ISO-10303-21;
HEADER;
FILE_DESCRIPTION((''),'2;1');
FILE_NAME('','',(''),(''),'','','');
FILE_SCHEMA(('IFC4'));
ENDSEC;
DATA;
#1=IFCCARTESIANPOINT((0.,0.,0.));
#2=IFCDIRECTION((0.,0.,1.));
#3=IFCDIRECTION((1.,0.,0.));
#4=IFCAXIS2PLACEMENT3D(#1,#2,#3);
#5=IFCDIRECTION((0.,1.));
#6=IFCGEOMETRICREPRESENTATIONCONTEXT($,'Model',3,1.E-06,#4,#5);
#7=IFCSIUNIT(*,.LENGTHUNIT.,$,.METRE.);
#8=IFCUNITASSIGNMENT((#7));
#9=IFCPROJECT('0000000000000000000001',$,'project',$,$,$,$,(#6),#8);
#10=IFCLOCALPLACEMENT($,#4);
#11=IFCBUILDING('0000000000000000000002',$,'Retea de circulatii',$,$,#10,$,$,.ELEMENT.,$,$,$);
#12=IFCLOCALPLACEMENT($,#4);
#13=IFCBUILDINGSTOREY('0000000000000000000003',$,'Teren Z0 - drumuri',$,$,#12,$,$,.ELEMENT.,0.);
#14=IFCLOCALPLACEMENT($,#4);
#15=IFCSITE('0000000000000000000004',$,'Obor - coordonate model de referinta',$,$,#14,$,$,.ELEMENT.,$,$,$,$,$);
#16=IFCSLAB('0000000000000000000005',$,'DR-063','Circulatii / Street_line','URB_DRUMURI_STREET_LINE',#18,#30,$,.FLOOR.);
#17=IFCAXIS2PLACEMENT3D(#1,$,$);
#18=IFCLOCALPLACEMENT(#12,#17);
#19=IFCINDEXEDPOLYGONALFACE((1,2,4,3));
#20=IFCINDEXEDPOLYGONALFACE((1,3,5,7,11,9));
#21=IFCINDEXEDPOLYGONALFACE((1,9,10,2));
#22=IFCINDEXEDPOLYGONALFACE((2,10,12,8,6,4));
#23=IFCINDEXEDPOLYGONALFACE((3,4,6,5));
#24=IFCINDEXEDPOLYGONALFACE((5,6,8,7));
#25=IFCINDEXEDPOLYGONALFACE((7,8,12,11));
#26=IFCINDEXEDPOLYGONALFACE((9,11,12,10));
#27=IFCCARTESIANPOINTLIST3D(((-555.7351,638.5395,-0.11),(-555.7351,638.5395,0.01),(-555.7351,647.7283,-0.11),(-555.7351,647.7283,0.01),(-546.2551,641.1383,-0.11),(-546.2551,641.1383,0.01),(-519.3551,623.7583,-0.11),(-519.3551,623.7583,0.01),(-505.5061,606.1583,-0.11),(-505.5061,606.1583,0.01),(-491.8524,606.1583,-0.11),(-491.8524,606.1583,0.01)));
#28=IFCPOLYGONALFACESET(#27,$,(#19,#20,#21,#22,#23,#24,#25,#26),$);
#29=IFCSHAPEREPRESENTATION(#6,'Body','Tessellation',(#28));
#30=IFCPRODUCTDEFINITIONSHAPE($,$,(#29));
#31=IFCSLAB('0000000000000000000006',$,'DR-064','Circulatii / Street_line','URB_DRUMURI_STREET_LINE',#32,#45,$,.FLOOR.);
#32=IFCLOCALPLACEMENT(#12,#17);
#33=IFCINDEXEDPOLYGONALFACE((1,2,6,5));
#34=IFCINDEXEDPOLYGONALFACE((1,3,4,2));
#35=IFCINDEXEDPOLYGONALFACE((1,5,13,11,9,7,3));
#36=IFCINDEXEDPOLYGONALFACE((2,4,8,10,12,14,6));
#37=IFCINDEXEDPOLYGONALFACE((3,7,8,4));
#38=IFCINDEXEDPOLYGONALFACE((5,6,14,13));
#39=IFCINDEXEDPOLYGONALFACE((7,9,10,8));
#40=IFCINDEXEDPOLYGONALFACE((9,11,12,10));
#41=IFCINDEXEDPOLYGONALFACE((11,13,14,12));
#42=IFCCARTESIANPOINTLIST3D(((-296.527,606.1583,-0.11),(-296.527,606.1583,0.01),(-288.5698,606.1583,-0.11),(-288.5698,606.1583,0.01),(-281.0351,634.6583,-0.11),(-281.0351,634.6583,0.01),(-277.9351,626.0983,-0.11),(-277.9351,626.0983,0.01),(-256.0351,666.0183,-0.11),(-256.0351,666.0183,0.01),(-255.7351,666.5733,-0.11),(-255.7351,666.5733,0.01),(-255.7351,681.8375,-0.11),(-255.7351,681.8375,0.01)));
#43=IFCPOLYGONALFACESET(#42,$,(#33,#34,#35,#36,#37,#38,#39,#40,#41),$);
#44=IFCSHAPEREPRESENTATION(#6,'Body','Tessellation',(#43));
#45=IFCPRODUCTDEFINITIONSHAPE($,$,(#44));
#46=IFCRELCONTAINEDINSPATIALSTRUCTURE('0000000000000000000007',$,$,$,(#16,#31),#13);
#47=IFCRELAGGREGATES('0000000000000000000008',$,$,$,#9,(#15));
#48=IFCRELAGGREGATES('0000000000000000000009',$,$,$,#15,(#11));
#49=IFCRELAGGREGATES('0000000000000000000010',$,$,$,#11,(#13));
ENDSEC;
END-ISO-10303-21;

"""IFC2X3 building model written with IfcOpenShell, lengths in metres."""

from ifc_helpers import new_model, si_unit, direction, frame, origin_with_axes, place, context, project, spatial, polyline, outline, extrude, element, save


model = new_model("IFC2X3")

# Units and contexts
model_context = context("Model", 3, precision=1e-06, world=origin_with_axes(), true_north=direction((0.0, 1.0)))
ifc_project = project(units=[si_unit("LENGTHUNIT", "METRE")], contexts=[model_context])

# Site, building, storey
site_placement = place(None, origin_with_axes())
site = spatial("IfcSite", under=ifc_project, at=site_placement, Name="Obor - coordonate model de referinta", CompositionType="ELEMENT")
building_placement = place(None, origin_with_axes())
building = spatial("IfcBuilding", under=site, at=building_placement, Name="Retea de circulatii", CompositionType="ELEMENT")
storey_placement = place(None, origin_with_axes())
storey = spatial("IfcBuildingStorey", under=building, at=storey_placement, Name="Teren Z0 - drumuri", CompositionType="ELEMENT", Elevation=0.0)

# Slabs
slab_1_placement = place(None, origin_with_axes())
element("IfcSlab", 1, at=slab_1_placement, inside=storey, Name="DR-063", Description="Circulatii / Street_line", ObjectType="URB_DRUMURI_STREET_LINE", PredefinedType="FLOOR", context=model_context, shape_type="SweptSolid", body=[
    extrude(outline(polyline([(-546.2551, 641.1383), (-555.7351, 647.7283), (-555.7351, 638.5395), (-505.5061, 606.1583), (-491.8524, 606.1583), (-519.3551, 623.7583), (-546.2551, 641.1383)])), frame((0.0, 0.0, -0.11), z_axis=(0.0, 0.0, 1.0), x_axis=(1.0, 0.0, 0.0)), (0.0, 0.0, 1.0), 0.12),
])
slab_2_placement = place(None, origin_with_axes())
element("IfcSlab", 2, at=slab_2_placement, inside=storey, Name="DR-064", Description="Circulatii / Street_line", ObjectType="URB_DRUMURI_STREET_LINE", PredefinedType="FLOOR", context=model_context, shape_type="SweptSolid", body=[
    extrude(outline(polyline([(-296.527, 606.1583), (-288.5698, 606.1583), (-277.9351, 626.0983), (-256.0351, 666.0183), (-255.7351, 666.5733), (-255.7351, 681.8375), (-281.0351, 634.6583), (-296.527, 606.1583)])), frame((0.0, 0.0, -0.11), z_axis=(0.0, 0.0, 1.0), x_axis=(1.0, 0.0, 0.0)), (0.0, 0.0, 1.0), 0.12),
])

save(model, "model.ifc")
